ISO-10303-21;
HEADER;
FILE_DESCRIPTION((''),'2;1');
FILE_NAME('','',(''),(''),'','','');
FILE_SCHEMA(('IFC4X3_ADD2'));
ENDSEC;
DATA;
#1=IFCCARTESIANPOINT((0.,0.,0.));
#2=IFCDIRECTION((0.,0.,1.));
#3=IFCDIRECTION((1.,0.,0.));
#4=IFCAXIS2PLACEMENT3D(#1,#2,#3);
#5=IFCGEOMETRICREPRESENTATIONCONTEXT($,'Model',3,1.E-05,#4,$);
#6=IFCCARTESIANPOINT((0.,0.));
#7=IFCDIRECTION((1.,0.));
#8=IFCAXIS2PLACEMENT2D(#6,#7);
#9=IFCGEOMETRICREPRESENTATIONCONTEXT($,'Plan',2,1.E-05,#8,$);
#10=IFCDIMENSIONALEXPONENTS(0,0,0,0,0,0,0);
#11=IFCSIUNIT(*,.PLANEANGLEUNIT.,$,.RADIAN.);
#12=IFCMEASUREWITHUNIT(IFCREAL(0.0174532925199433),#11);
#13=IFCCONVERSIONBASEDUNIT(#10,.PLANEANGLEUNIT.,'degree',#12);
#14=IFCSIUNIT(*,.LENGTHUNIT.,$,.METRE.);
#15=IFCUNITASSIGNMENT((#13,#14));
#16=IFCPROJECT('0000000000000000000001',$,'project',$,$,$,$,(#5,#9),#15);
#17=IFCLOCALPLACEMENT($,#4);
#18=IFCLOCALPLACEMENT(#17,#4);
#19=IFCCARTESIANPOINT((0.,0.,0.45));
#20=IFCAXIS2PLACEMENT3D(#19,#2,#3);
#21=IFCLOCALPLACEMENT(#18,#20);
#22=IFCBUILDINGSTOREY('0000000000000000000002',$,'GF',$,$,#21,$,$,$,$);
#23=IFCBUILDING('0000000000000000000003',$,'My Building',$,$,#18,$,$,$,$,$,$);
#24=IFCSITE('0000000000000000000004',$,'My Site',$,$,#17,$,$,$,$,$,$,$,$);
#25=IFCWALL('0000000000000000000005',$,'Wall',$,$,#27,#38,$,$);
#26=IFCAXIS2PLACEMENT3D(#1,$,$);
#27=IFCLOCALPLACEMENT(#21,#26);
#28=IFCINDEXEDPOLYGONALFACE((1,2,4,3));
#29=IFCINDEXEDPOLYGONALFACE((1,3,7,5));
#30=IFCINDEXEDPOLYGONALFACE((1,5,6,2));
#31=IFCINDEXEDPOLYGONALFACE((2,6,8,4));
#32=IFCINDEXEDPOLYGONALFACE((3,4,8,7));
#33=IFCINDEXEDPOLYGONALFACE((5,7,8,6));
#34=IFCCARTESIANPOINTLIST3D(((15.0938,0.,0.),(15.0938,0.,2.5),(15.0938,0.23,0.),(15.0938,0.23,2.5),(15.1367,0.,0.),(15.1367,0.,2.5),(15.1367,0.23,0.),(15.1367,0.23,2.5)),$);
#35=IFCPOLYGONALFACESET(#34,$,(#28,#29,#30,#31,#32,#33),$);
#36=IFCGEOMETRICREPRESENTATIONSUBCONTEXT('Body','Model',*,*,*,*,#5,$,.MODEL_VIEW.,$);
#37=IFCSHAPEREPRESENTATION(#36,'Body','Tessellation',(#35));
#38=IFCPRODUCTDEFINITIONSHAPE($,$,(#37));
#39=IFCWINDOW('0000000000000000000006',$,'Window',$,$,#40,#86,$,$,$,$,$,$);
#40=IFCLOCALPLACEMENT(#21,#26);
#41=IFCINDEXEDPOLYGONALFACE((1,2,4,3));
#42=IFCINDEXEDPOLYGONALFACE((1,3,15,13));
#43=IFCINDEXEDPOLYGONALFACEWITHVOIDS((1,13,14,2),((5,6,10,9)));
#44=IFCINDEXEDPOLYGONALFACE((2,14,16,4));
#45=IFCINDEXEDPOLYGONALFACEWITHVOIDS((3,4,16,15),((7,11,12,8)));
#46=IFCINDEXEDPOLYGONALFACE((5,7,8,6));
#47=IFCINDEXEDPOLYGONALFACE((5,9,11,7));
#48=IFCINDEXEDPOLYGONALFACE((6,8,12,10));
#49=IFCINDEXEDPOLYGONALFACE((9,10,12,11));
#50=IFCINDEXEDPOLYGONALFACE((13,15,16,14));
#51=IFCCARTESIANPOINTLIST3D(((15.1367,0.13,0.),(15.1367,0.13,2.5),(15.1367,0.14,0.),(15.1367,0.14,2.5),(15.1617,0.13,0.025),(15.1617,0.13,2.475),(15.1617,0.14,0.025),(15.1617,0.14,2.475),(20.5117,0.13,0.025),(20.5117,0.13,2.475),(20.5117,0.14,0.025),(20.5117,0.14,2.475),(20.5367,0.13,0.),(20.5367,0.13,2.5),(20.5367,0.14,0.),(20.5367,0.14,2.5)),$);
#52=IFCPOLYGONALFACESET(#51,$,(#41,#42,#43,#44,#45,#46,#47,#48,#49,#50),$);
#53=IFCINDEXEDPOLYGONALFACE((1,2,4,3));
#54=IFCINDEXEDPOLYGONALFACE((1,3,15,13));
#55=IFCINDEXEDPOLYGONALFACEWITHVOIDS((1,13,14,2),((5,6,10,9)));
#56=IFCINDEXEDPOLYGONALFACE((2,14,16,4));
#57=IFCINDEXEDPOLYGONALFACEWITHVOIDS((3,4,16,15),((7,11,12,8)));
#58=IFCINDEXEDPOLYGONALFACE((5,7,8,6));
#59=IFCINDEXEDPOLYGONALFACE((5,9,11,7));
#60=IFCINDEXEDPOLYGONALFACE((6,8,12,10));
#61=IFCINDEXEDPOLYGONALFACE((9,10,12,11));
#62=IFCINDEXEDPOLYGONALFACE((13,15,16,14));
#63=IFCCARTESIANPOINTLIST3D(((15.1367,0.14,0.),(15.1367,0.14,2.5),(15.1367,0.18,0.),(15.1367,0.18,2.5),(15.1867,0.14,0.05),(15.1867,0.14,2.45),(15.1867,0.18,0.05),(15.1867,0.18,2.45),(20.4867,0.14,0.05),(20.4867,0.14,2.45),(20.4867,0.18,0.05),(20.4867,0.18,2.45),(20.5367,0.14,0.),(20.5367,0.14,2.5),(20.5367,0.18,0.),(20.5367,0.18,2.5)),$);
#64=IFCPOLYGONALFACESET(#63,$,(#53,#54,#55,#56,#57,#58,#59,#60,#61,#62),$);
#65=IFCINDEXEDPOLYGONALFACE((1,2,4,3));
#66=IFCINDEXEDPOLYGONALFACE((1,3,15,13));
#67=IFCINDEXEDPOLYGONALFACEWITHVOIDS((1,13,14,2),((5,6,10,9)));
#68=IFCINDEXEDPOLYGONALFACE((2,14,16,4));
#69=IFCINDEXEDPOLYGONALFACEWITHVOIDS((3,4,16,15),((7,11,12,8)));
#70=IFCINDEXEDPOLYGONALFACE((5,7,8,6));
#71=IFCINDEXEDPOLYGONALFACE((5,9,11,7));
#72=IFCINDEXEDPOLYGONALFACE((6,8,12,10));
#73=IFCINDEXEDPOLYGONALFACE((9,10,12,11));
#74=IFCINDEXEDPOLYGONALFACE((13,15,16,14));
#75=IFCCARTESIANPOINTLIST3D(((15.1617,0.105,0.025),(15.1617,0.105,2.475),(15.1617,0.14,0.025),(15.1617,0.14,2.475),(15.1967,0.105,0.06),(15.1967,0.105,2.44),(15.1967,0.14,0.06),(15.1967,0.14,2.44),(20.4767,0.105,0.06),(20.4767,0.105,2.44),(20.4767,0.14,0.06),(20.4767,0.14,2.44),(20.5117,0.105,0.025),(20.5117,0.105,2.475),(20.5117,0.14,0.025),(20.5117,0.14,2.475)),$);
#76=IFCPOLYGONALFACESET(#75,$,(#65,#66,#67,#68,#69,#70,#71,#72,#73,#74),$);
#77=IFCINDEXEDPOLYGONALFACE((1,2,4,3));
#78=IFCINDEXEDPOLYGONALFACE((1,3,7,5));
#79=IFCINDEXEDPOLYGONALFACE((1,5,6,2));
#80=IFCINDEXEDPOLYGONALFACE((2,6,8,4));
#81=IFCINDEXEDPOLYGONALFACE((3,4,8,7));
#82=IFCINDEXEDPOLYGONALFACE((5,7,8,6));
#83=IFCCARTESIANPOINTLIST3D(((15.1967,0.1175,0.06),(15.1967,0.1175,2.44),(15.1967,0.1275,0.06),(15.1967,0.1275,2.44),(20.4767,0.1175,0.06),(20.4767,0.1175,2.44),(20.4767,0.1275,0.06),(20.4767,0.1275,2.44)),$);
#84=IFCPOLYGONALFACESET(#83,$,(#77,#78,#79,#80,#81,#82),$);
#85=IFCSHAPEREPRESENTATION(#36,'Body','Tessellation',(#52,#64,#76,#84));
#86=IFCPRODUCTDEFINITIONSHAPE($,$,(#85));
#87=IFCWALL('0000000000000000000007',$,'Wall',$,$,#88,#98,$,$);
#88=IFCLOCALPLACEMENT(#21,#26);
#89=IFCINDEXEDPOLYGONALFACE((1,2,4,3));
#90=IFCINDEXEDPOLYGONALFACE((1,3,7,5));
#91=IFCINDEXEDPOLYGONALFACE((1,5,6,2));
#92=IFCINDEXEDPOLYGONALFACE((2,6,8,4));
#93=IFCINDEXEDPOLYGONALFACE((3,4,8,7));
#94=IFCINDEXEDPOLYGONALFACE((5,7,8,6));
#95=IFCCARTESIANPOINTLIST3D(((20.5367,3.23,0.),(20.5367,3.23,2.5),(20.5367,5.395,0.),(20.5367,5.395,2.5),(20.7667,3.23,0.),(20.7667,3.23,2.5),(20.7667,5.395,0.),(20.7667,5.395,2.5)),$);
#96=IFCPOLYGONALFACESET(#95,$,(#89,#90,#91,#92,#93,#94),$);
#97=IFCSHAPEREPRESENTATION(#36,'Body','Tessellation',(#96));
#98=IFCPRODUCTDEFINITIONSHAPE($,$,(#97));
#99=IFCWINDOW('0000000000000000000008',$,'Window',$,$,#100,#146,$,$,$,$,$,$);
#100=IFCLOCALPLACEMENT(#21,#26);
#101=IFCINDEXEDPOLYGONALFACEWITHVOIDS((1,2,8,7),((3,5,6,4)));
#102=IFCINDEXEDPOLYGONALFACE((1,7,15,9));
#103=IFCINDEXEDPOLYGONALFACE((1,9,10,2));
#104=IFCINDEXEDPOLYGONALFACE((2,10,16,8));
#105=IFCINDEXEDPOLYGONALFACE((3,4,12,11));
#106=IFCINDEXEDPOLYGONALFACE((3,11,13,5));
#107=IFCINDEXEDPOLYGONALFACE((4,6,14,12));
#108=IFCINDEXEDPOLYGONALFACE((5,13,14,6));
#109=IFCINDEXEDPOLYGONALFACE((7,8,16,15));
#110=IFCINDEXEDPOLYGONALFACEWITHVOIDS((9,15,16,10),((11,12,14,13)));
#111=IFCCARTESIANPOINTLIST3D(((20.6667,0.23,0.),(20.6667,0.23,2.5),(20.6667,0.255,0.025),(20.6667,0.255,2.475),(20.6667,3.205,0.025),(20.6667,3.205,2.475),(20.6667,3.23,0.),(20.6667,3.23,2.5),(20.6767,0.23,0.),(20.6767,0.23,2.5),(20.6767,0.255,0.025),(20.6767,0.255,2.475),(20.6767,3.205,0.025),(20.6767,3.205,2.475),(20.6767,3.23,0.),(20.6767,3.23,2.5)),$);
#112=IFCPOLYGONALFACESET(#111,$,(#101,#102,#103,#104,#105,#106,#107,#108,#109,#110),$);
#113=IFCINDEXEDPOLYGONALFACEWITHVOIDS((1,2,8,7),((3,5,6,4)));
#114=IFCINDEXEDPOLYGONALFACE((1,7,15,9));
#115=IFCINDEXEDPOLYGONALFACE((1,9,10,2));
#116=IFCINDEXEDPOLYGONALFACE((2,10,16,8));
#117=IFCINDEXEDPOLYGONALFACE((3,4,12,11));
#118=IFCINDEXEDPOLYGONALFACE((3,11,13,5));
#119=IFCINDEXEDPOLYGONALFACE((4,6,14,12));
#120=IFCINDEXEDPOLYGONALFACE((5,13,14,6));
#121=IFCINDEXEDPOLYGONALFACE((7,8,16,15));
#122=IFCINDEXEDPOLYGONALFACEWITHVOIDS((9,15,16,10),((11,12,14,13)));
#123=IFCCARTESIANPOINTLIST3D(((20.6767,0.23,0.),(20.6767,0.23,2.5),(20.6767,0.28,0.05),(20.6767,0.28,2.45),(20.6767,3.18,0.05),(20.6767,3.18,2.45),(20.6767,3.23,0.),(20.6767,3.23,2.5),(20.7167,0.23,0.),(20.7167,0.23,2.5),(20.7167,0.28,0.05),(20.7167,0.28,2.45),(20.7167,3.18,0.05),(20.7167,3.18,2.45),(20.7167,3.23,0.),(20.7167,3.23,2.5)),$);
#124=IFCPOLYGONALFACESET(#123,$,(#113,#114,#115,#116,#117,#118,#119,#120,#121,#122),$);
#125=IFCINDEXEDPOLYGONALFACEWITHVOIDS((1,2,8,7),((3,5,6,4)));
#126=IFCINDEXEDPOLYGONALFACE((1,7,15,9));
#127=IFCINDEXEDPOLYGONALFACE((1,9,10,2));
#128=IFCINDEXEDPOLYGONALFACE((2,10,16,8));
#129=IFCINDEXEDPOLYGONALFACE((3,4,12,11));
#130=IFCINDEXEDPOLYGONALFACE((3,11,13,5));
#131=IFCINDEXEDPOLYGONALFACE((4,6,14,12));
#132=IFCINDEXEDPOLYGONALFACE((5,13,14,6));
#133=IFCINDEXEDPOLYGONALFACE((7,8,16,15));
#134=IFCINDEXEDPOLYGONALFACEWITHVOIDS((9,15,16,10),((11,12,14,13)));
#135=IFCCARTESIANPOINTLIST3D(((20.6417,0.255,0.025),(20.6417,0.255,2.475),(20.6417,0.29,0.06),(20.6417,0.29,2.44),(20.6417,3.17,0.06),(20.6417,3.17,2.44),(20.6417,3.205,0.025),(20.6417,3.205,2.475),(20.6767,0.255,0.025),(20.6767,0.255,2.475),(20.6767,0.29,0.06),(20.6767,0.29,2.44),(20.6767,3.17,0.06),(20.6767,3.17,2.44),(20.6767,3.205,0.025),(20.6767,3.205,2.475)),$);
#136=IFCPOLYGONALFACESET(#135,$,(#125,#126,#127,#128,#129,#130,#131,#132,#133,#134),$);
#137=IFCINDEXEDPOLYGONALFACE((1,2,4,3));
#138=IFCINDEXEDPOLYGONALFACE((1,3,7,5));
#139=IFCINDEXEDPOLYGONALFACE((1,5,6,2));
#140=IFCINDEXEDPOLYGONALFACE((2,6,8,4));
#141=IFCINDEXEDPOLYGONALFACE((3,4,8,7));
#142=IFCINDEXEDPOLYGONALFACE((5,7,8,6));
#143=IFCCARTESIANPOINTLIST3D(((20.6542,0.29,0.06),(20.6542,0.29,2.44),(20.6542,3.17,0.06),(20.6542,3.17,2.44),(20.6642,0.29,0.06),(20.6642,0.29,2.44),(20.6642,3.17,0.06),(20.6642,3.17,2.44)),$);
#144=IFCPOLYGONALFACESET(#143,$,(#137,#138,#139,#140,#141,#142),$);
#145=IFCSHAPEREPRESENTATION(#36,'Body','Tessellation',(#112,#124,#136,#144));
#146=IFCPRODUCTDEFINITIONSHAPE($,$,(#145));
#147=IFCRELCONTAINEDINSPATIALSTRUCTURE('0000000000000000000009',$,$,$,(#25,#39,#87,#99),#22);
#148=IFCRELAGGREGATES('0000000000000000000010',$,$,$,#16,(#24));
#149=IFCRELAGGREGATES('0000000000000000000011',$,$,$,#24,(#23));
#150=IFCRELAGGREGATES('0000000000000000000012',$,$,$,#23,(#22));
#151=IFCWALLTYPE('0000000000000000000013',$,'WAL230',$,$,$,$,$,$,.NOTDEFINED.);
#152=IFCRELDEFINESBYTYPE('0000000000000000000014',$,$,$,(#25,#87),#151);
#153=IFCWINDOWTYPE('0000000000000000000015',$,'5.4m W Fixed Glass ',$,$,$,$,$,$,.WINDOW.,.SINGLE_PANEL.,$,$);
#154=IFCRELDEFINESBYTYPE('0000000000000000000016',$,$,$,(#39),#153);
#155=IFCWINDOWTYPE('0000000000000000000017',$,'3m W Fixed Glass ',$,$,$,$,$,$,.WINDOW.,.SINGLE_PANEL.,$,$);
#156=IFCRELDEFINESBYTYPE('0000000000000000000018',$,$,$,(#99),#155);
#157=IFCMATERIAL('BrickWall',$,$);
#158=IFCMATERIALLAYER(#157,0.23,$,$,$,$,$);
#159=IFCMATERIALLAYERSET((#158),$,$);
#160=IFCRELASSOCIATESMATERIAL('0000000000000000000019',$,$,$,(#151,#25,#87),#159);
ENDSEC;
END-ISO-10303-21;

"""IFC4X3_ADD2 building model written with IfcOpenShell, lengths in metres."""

from ifc_helpers import new_model, entity, si_unit, converted_unit, frame, origin_with_axes, origin_2d_with_axis, place, context, subcontext, project, spatial, line, indexed_curve, outline, extrude, shape, source, transform, mapped, material, layer, layer_set, layer_usage, type_object, type_shapes, element, fill, save


model = new_model("IFC4X3_ADD2")

# Units and contexts
model_context = context("Model", 3, precision=1e-05, world=origin_with_axes())
plan_context = context("Plan", 2, precision=1e-05, world=origin_2d_with_axis())
body_context_1 = subcontext(model_context, "Body", "Model", "MODEL_VIEW")
body_context_2 = subcontext(plan_context, "Body", "Plan", "PLAN_VIEW")
ifc_project = project(units=[converted_unit("PLANEANGLEUNIT", "degree", entity("IfcReal", 0.0174532925199433), si_unit("PLANEANGLEUNIT", "RADIAN"), dimensions=[0, 0, 0, 0, 0, 0, 0]), si_unit("LENGTHUNIT", "METRE")], contexts=[model_context, plan_context])

# Site, building, storey
site_placement = place(None, origin_with_axes())
site = spatial("IfcSite", under=ifc_project, at=site_placement, Name="My Site")
building_placement = place(site_placement, origin_with_axes())
building = spatial("IfcBuilding", under=site, at=building_placement, Name="My Building")
storey_placement = place(building_placement, frame((0.0, 0.0, 0.45), z_axis=(0.0, 0.0, 1.0), x_axis=(1.0, 0.0, 0.0)))
storey = spatial("IfcBuildingStorey", under=building, at=storey_placement, Name="GF")

# Walls, openings, windows
ifc_material = material(Name="BrickWall")
ifc_layer_1 = layer(ifc_material, 0.23)
ifc_layer_set_1 = layer_set([ifc_layer_1])
ifc_layer_usage_1 = layer_usage(ifc_layer_set_1, "AXIS2", "POSITIVE", 0.0)
wall_type_1 = type_object("IfcWallType", Name="WAL230", PredefinedType="NOTDEFINED", material=ifc_layer_set_1)
wall_1_placement = place(storey_placement, frame((20.5367, 0.23, 0.0), z_axis=(0.0, 0.0, 1.0), x_axis=(-1.0, 0.0, 0.0)))
wall_1 = element("IfcWall", 1, at=wall_1_placement, inside=storey, type_object=wall_type_1, material=ifc_layer_usage_1, Name="Wall", context=body_context_1, shape_type="SweptSolid", body=[
    extrude(outline(indexed_curve([(0.0, 0.0), (0.0, 0.23), (5.4429, 0.23), (5.4429, 0.0), (0.0, 0.0)], self_intersect=False)), origin_with_axes(), (0.0, 0.0, 1.0), 2.5),
])
shared_shape_1 = source(origin_with_axes(), body_context_1, "Body", "SweptSolid", [
    extrude(outline(indexed_curve([(0.0, 0.0), (5.4, 0.0), (5.4, 2.5), (0.0, 2.5)], segments=[line(1, 2, 3, 4, 1)])), frame((0.0, -0.6, 0.0), z_axis=(0.0, -1.0, 0.0), x_axis=(1.0, 0.0, 0.0)), (0.0, 0.0, -1.0), 1.2),
])
opening_1_placement = place(wall_1_placement, frame((0.0, 0.0, 0.0), z_axis=(0.0, 0.0, 1.0), x_axis=(1.0, 0.0, 0.0)))
opening_1 = element("IfcOpeningElement", 2, at=opening_1_placement, cuts=wall_1, PredefinedType="OPENING", context=body_context_1, shape_type="MappedRepresentation", body=[
    mapped(shared_shape_1, transform((0.0, 0.0, 0.0), x_axis=(1.0, 0.0, 0.0), y_axis=(0.0, 1.0, 0.0), z_axis=(0.0, 0.0, 1.0), scale=1.0)),
])
window_type_1 = type_object("IfcWindowType", Name="5.4m W Fixed Glass ", PartitioningType="SINGLE_PANEL", PredefinedType="WINDOW")
shared_shape_2 = source(origin_with_axes(), body_context_1, "Body", "SweptSolid", [
    extrude(outline(indexed_curve([(0.0, 0.0), (5.4, 0.0), (5.4, 2.5), (0.0, 2.5)], segments=[line(1, 2, 3, 4, 1)]), holes=[indexed_curve([(0.025, 0.025), (5.375, 0.025), (5.375, 2.475), (0.025, 2.475)], segments=[line(1, 2, 3, 4, 1)])]), frame((0.0, 0.09, 0.0), z_axis=(0.0, -1.0, 0.0), x_axis=(1.0, 0.0, 0.0)), (0.0, 0.0, -1.0), 0.01),
    extrude(outline(indexed_curve([(0.0, 0.0), (5.4, 0.0), (5.4, 2.5), (0.0, 2.5)], segments=[line(1, 2, 3, 4, 1)]), holes=[indexed_curve([(0.05, 0.05), (5.35, 0.05), (5.35, 2.45), (0.05, 2.45)], segments=[line(1, 2, 3, 4, 1)])]), frame((0.0, 0.05, 0.0), z_axis=(0.0, -1.0, 0.0), x_axis=(1.0, 0.0, 0.0)), (0.0, 0.0, -1.0), 0.04),
    extrude(outline(indexed_curve([(0.0, 0.0), (5.35, 0.0), (5.35, 2.45), (0.0, 2.45)], segments=[line(1, 2, 3, 4, 1)]), holes=[indexed_curve([(0.035, 0.035), (5.315, 0.035), (5.315, 2.415), (0.035, 2.415)], segments=[line(1, 2, 3, 4, 1)])]), frame((0.025, 0.09, 0.025), z_axis=(0.0, -1.0, 0.0), x_axis=(1.0, 0.0, 0.0)), (0.0, 0.0, -1.0), 0.035),
    extrude(outline(indexed_curve([(0.035, 0.035), (5.315, 0.035), (5.315, 2.415), (0.035, 2.415)], segments=[line(1, 2, 3, 4, 1)])), frame((0.025, 0.1025, 0.025), z_axis=(0.0, -1.0, 0.0), x_axis=(1.0, 0.0, 0.0)), (0.0, 0.0, -1.0), 0.01),
])
shared_shape_3 = source(origin_with_axes(), body_context_2, "Body", "Curve2D", [
    entity("IfcIndexedPolyCurve", entity("IfcCartesianPointList2D", [[0.05, 0.05], [5.35, 0.05]])),
    entity("IfcIndexedPolyCurve", entity("IfcCartesianPointList2D", [[0.0, 0.1], [0.025, 0.1], [0.025, 0.09], [0.05, 0.09], [0.05, 0.05], [0.0, 0.05]]), [entity("IfcLineIndex", [1, 2, 3, 4, 5, 6, 1])]),
    entity("IfcIndexedPolyCurve", entity("IfcCartesianPointList2D", [[5.4, 0.1], [5.375, 0.1], [5.375, 0.09], [5.35, 0.09], [5.35, 0.05], [5.4, 0.05]]), [entity("IfcLineIndex", [1, 2, 3, 4, 5, 6, 1])]),
    entity("IfcIndexedPolyCurve", entity("IfcCartesianPointList2D", [[0.025, 0.09], [0.06, 0.09], [0.06, 0.125], [0.025, 0.125]]), [entity("IfcLineIndex", [1, 2, 3, 4, 1])]),
    entity("IfcIndexedPolyCurve", entity("IfcCartesianPointList2D", [[5.375, 0.09], [5.34, 0.09], [5.34, 0.125], [5.375, 0.125]]), [entity("IfcLineIndex", [1, 2, 3, 4, 1])]),
    entity("IfcIndexedPolyCurve", entity("IfcCartesianPointList2D", [[0.06, 0.09], [5.34, 0.09]])),
    entity("IfcIndexedPolyCurve", entity("IfcCartesianPointList2D", [[0.06, 0.125], [5.34, 0.125]])),
    entity("IfcIndexedPolyCurve", entity("IfcCartesianPointList2D", [[0.06, 0.1075], [5.34, 0.1075]])),
])
type_shapes(window_type_1, [shared_shape_2, shared_shape_3])
window_1_placement = place(opening_1_placement, frame((0.0, 0.0, 0.0), z_axis=(0.0, 0.0, 1.0), x_axis=(1.0, 0.0, 0.0)))
window_1 = element("IfcWindow", 3, at=window_1_placement, inside=storey, type_object=window_type_1, Name="Window", shapes=[
    shape(body_context_1, "Body", "MappedRepresentation", [mapped(shared_shape_2, transform((0.0, 0.0, 0.0), x_axis=(1.0, 0.0, 0.0), y_axis=(0.0, 1.0, 0.0), z_axis=(0.0, 0.0, 1.0), scale=1.0))]),
    shape(body_context_2, "Body", "MappedRepresentation", [mapped(shared_shape_3, transform((0.0, 0.0, 0.0), x_axis=(1.0, 0.0, 0.0), y_axis=(0.0, 1.0, 0.0), z_axis=(0.0, 0.0, 1.0), scale=1.0))]),
])
fill(opening_1, window_1)
ifc_layer_usage_2 = layer_usage(ifc_layer_set_1, "AXIS2", "POSITIVE", 0.0)
wall_2_placement = place(storey_placement, frame((20.7667, 0.23, 0.0), z_axis=(0.0, 0.0, 1.0), x_axis=(0.0, 1.0, 0.0)))
wall_2 = element("IfcWall", 4, at=wall_2_placement, inside=storey, type_object=wall_type_1, material=ifc_layer_usage_2, Name="Wall", context=body_context_1, shape_type="SweptSolid", body=[
    extrude(outline(indexed_curve([(0.0, 0.0), (0.0, 0.23), (5.165, 0.23), (5.165, 0.0), (0.0, 0.0)], self_intersect=False)), origin_with_axes(), (0.0, 0.0, 1.0), 2.5),
])
shared_shape_4 = source(origin_with_axes(), body_context_1, "Body", "SweptSolid", [
    extrude(outline(indexed_curve([(0.0, 0.0), (3.0, 0.0), (3.0, 2.5), (0.0, 2.5)], segments=[line(1, 2, 3, 4, 1)])), frame((0.0, -0.6, 0.0), z_axis=(0.0, -1.0, 0.0), x_axis=(1.0, 0.0, 0.0)), (0.0, 0.0, -1.0), 1.2),
])
opening_2_placement = place(wall_2_placement, frame((0.0, 0.0, 0.0), z_axis=(0.0, 0.0, 1.0), x_axis=(1.0, 0.0, 0.0)))
opening_2 = element("IfcOpeningElement", 5, at=opening_2_placement, cuts=wall_2, PredefinedType="OPENING", context=body_context_1, shape_type="MappedRepresentation", body=[
    mapped(shared_shape_4, transform((0.0, 0.0, 0.0), x_axis=(1.0, 0.0, 0.0), y_axis=(0.0, 1.0, 0.0), z_axis=(0.0, 0.0, 1.0), scale=1.0)),
])
window_type_2 = type_object("IfcWindowType", Name="3m W Fixed Glass ", PartitioningType="SINGLE_PANEL", PredefinedType="WINDOW")
shared_shape_5 = source(origin_with_axes(), body_context_1, "Body", "SweptSolid", [
    extrude(outline(indexed_curve([(0.0, 0.0), (3.0, 0.0), (3.0, 2.5), (0.0, 2.5)], segments=[line(1, 2, 3, 4, 1)]), holes=[indexed_curve([(0.025, 0.025), (2.975, 0.025), (2.975, 2.475), (0.025, 2.475)], segments=[line(1, 2, 3, 4, 1)])]), frame((0.0, 0.09, 0.0), z_axis=(0.0, -1.0, 0.0), x_axis=(1.0, 0.0, 0.0)), (0.0, 0.0, -1.0), 0.01),
    extrude(outline(indexed_curve([(0.0, 0.0), (3.0, 0.0), (3.0, 2.5), (0.0, 2.5)], segments=[line(1, 2, 3, 4, 1)]), holes=[indexed_curve([(0.05, 0.05), (2.95, 0.05), (2.95, 2.45), (0.05, 2.45)], segments=[line(1, 2, 3, 4, 1)])]), frame((0.0, 0.05, 0.0), z_axis=(0.0, -1.0, 0.0), x_axis=(1.0, 0.0, 0.0)), (0.0, 0.0, -1.0), 0.04),
    extrude(outline(indexed_curve([(0.0, 0.0), (2.95, 0.0), (2.95, 2.45), (0.0, 2.45)], segments=[line(1, 2, 3, 4, 1)]), holes=[indexed_curve([(0.035, 0.035), (2.915, 0.035), (2.915, 2.415), (0.035, 2.415)], segments=[line(1, 2, 3, 4, 1)])]), frame((0.025, 0.09, 0.025), z_axis=(0.0, -1.0, 0.0), x_axis=(1.0, 0.0, 0.0)), (0.0, 0.0, -1.0), 0.035),
    extrude(outline(indexed_curve([(0.035, 0.035), (2.915, 0.035), (2.915, 2.415), (0.035, 2.415)], segments=[line(1, 2, 3, 4, 1)])), frame((0.025, 0.1025, 0.025), z_axis=(0.0, -1.0, 0.0), x_axis=(1.0, 0.0, 0.0)), (0.0, 0.0, -1.0), 0.01),
])
shared_shape_6 = source(origin_with_axes(), body_context_2, "Body", "Curve2D", [
    entity("IfcIndexedPolyCurve", entity("IfcCartesianPointList2D", [[0.05, 0.05], [2.95, 0.05]])),
    entity("IfcIndexedPolyCurve", entity("IfcCartesianPointList2D", [[0.0, 0.1], [0.025, 0.1], [0.025, 0.09], [0.05, 0.09], [0.05, 0.05], [0.0, 0.05]]), [entity("IfcLineIndex", [1, 2, 3, 4, 5, 6, 1])]),
    entity("IfcIndexedPolyCurve", entity("IfcCartesianPointList2D", [[3.0, 0.1], [2.975, 0.1], [2.975, 0.09], [2.95, 0.09], [2.95, 0.05], [3.0, 0.05]]), [entity("IfcLineIndex", [1, 2, 3, 4, 5, 6, 1])]),
    entity("IfcIndexedPolyCurve", entity("IfcCartesianPointList2D", [[0.025, 0.09], [0.06, 0.09], [0.06, 0.125], [0.025, 0.125]]), [entity("IfcLineIndex", [1, 2, 3, 4, 1])]),
    entity("IfcIndexedPolyCurve", entity("IfcCartesianPointList2D", [[2.975, 0.09], [2.94, 0.09], [2.94, 0.125], [2.975, 0.125]]), [entity("IfcLineIndex", [1, 2, 3, 4, 1])]),
    entity("IfcIndexedPolyCurve", entity("IfcCartesianPointList2D", [[0.06, 0.09], [2.94, 0.09]])),
    entity("IfcIndexedPolyCurve", entity("IfcCartesianPointList2D", [[0.06, 0.125], [2.94, 0.125]])),
    entity("IfcIndexedPolyCurve", entity("IfcCartesianPointList2D", [[0.06, 0.1075], [2.94, 0.1075]])),
])
type_shapes(window_type_2, [shared_shape_5, shared_shape_6])
window_2_placement = place(opening_2_placement, frame((0.0, 0.0, 0.0), z_axis=(0.0, 0.0, 1.0), x_axis=(1.0, 0.0, 0.0)))
window_2 = element("IfcWindow", 6, at=window_2_placement, inside=storey, type_object=window_type_2, Name="Window", shapes=[
    shape(body_context_1, "Body", "MappedRepresentation", [mapped(shared_shape_5, transform((0.0, 0.0, 0.0), x_axis=(1.0, 0.0, 0.0), y_axis=(0.0, 1.0, 0.0), z_axis=(0.0, 0.0, 1.0), scale=1.0))]),
    shape(body_context_2, "Body", "MappedRepresentation", [mapped(shared_shape_6, transform((0.0, 0.0, 0.0), x_axis=(1.0, 0.0, 0.0), y_axis=(0.0, 1.0, 0.0), z_axis=(0.0, 0.0, 1.0), scale=1.0))]),
])
fill(opening_2, window_2)

save(model, "model.ifc")
